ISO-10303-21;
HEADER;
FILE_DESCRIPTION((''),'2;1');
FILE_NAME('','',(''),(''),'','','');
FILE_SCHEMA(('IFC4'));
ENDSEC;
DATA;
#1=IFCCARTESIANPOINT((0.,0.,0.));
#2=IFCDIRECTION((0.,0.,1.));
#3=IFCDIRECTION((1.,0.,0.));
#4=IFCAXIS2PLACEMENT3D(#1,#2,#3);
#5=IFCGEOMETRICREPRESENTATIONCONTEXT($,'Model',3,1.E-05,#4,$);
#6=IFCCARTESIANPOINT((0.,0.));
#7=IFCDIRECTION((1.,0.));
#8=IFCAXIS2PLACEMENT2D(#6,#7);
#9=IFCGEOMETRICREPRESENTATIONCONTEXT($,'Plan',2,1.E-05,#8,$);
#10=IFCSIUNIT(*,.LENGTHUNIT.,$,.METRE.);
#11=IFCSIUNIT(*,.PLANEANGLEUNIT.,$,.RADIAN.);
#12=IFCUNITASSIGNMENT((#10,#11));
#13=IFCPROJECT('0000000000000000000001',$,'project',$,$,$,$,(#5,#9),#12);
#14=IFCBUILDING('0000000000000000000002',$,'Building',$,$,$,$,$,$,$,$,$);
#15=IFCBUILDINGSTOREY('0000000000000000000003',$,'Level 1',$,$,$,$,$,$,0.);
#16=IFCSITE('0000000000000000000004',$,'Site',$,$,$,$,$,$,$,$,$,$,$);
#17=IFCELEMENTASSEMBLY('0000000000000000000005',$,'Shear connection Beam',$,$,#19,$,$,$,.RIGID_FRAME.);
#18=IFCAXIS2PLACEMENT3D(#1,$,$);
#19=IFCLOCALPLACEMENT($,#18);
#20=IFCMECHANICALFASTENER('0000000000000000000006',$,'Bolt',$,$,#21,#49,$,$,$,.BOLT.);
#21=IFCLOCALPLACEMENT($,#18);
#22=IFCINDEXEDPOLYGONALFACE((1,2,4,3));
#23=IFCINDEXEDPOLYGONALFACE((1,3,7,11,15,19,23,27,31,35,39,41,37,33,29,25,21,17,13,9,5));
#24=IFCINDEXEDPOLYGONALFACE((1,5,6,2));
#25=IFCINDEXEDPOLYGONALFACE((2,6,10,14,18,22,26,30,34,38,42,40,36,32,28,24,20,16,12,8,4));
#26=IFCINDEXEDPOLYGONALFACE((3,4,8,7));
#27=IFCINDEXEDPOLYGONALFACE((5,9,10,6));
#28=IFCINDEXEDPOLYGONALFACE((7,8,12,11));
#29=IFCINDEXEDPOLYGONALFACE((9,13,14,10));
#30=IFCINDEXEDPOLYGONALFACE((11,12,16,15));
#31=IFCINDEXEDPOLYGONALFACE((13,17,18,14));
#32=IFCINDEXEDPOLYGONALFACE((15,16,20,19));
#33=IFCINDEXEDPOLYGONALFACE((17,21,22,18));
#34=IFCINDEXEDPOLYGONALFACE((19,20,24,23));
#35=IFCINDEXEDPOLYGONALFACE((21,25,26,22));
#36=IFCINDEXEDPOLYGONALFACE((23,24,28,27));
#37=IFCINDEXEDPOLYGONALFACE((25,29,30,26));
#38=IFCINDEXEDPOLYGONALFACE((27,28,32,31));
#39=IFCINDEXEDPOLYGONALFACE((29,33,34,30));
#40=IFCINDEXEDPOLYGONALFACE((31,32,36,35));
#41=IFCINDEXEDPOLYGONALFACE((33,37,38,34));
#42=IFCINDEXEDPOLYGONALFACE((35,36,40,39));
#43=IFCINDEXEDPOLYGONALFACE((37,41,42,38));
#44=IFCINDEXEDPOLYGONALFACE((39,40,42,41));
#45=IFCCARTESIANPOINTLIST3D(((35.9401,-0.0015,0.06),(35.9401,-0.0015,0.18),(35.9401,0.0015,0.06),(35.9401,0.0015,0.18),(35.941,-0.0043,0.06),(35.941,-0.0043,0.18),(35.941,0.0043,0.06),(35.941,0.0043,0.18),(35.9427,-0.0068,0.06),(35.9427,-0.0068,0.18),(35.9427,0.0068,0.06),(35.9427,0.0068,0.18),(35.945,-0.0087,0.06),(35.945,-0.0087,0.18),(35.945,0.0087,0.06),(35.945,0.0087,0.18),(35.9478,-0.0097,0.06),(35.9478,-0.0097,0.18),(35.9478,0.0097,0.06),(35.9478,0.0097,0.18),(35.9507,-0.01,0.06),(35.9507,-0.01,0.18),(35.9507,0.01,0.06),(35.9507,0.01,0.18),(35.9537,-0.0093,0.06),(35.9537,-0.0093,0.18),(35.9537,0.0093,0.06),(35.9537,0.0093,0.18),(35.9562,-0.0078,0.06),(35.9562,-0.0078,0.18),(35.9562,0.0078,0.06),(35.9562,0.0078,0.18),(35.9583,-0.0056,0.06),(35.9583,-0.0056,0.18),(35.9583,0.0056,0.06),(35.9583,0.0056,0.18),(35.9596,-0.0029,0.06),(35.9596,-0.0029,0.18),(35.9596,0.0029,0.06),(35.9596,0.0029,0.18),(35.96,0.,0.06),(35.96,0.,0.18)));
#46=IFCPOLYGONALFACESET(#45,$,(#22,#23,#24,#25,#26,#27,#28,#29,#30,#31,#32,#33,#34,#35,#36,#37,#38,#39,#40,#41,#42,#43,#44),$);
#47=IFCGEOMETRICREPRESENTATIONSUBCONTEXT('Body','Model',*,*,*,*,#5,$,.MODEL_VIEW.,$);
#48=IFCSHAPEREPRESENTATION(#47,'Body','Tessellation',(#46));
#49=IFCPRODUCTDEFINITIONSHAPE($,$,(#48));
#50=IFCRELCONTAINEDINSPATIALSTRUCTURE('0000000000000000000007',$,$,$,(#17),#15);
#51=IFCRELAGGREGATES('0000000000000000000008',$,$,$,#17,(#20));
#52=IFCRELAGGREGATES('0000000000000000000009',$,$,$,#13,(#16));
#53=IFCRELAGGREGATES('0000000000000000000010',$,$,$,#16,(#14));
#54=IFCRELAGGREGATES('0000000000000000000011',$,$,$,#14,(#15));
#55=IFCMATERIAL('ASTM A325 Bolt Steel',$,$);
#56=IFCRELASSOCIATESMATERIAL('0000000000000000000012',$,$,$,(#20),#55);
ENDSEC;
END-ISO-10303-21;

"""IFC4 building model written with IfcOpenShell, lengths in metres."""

from ifc_helpers import new_model, si_unit, frame, origin_with_axes, origin_2d, origin_2d_with_axis, place, context, subcontext, project, spatial, circle, extrude, material, element, aggregate, save


model = new_model("IFC4")

# Units and contexts
model_context = context("Model", 3, precision=1e-05, world=origin_with_axes())
plan_context = context("Plan", 2, precision=1e-05, world=origin_2d_with_axis())
body_context = subcontext(model_context, "Body", "Model", "MODEL_VIEW")
ifc_project = project(units=[si_unit("LENGTHUNIT", "METRE"), si_unit("PLANEANGLEUNIT", "RADIAN")], contexts=[model_context, plan_context])

# Site, building, storey
site = spatial("IfcSite", under=ifc_project, Name="Site")
building = spatial("IfcBuilding", under=site, Name="Building")
storey = spatial("IfcBuildingStorey", under=building, Name="Level 1", Elevation=0.0)

# Element assembly
assembly_1 = element("IfcElementAssembly", 1, inside=storey, Name="Shear connection Beam", PredefinedType="RIGID_FRAME")

# Shared definitions
ifc_material_1 = material(Name="ASTM A325 Bolt Steel")

# Mechanical fastener
mechanical_fastener_1_placement = place(None, frame((35.95, 0.0, 0.06), z_axis=(0.0, 0.0, 1.0), x_axis=(1.0, 0.0, 0.0)))
mechanical_fastener_1 = element("IfcMechanicalFastener", 2, at=mechanical_fastener_1_placement, material=ifc_material_1, Name="Bolt", PredefinedType="BOLT", context=body_context, shape_type="SweptSolid", body=[
    extrude(circle(Radius=0.01, at=origin_2d()), origin_with_axes(), (0.0, 0.0, 1.0), 0.12),
])
aggregate(assembly_1, [mechanical_fastener_1])

save(model, "model.ifc")
